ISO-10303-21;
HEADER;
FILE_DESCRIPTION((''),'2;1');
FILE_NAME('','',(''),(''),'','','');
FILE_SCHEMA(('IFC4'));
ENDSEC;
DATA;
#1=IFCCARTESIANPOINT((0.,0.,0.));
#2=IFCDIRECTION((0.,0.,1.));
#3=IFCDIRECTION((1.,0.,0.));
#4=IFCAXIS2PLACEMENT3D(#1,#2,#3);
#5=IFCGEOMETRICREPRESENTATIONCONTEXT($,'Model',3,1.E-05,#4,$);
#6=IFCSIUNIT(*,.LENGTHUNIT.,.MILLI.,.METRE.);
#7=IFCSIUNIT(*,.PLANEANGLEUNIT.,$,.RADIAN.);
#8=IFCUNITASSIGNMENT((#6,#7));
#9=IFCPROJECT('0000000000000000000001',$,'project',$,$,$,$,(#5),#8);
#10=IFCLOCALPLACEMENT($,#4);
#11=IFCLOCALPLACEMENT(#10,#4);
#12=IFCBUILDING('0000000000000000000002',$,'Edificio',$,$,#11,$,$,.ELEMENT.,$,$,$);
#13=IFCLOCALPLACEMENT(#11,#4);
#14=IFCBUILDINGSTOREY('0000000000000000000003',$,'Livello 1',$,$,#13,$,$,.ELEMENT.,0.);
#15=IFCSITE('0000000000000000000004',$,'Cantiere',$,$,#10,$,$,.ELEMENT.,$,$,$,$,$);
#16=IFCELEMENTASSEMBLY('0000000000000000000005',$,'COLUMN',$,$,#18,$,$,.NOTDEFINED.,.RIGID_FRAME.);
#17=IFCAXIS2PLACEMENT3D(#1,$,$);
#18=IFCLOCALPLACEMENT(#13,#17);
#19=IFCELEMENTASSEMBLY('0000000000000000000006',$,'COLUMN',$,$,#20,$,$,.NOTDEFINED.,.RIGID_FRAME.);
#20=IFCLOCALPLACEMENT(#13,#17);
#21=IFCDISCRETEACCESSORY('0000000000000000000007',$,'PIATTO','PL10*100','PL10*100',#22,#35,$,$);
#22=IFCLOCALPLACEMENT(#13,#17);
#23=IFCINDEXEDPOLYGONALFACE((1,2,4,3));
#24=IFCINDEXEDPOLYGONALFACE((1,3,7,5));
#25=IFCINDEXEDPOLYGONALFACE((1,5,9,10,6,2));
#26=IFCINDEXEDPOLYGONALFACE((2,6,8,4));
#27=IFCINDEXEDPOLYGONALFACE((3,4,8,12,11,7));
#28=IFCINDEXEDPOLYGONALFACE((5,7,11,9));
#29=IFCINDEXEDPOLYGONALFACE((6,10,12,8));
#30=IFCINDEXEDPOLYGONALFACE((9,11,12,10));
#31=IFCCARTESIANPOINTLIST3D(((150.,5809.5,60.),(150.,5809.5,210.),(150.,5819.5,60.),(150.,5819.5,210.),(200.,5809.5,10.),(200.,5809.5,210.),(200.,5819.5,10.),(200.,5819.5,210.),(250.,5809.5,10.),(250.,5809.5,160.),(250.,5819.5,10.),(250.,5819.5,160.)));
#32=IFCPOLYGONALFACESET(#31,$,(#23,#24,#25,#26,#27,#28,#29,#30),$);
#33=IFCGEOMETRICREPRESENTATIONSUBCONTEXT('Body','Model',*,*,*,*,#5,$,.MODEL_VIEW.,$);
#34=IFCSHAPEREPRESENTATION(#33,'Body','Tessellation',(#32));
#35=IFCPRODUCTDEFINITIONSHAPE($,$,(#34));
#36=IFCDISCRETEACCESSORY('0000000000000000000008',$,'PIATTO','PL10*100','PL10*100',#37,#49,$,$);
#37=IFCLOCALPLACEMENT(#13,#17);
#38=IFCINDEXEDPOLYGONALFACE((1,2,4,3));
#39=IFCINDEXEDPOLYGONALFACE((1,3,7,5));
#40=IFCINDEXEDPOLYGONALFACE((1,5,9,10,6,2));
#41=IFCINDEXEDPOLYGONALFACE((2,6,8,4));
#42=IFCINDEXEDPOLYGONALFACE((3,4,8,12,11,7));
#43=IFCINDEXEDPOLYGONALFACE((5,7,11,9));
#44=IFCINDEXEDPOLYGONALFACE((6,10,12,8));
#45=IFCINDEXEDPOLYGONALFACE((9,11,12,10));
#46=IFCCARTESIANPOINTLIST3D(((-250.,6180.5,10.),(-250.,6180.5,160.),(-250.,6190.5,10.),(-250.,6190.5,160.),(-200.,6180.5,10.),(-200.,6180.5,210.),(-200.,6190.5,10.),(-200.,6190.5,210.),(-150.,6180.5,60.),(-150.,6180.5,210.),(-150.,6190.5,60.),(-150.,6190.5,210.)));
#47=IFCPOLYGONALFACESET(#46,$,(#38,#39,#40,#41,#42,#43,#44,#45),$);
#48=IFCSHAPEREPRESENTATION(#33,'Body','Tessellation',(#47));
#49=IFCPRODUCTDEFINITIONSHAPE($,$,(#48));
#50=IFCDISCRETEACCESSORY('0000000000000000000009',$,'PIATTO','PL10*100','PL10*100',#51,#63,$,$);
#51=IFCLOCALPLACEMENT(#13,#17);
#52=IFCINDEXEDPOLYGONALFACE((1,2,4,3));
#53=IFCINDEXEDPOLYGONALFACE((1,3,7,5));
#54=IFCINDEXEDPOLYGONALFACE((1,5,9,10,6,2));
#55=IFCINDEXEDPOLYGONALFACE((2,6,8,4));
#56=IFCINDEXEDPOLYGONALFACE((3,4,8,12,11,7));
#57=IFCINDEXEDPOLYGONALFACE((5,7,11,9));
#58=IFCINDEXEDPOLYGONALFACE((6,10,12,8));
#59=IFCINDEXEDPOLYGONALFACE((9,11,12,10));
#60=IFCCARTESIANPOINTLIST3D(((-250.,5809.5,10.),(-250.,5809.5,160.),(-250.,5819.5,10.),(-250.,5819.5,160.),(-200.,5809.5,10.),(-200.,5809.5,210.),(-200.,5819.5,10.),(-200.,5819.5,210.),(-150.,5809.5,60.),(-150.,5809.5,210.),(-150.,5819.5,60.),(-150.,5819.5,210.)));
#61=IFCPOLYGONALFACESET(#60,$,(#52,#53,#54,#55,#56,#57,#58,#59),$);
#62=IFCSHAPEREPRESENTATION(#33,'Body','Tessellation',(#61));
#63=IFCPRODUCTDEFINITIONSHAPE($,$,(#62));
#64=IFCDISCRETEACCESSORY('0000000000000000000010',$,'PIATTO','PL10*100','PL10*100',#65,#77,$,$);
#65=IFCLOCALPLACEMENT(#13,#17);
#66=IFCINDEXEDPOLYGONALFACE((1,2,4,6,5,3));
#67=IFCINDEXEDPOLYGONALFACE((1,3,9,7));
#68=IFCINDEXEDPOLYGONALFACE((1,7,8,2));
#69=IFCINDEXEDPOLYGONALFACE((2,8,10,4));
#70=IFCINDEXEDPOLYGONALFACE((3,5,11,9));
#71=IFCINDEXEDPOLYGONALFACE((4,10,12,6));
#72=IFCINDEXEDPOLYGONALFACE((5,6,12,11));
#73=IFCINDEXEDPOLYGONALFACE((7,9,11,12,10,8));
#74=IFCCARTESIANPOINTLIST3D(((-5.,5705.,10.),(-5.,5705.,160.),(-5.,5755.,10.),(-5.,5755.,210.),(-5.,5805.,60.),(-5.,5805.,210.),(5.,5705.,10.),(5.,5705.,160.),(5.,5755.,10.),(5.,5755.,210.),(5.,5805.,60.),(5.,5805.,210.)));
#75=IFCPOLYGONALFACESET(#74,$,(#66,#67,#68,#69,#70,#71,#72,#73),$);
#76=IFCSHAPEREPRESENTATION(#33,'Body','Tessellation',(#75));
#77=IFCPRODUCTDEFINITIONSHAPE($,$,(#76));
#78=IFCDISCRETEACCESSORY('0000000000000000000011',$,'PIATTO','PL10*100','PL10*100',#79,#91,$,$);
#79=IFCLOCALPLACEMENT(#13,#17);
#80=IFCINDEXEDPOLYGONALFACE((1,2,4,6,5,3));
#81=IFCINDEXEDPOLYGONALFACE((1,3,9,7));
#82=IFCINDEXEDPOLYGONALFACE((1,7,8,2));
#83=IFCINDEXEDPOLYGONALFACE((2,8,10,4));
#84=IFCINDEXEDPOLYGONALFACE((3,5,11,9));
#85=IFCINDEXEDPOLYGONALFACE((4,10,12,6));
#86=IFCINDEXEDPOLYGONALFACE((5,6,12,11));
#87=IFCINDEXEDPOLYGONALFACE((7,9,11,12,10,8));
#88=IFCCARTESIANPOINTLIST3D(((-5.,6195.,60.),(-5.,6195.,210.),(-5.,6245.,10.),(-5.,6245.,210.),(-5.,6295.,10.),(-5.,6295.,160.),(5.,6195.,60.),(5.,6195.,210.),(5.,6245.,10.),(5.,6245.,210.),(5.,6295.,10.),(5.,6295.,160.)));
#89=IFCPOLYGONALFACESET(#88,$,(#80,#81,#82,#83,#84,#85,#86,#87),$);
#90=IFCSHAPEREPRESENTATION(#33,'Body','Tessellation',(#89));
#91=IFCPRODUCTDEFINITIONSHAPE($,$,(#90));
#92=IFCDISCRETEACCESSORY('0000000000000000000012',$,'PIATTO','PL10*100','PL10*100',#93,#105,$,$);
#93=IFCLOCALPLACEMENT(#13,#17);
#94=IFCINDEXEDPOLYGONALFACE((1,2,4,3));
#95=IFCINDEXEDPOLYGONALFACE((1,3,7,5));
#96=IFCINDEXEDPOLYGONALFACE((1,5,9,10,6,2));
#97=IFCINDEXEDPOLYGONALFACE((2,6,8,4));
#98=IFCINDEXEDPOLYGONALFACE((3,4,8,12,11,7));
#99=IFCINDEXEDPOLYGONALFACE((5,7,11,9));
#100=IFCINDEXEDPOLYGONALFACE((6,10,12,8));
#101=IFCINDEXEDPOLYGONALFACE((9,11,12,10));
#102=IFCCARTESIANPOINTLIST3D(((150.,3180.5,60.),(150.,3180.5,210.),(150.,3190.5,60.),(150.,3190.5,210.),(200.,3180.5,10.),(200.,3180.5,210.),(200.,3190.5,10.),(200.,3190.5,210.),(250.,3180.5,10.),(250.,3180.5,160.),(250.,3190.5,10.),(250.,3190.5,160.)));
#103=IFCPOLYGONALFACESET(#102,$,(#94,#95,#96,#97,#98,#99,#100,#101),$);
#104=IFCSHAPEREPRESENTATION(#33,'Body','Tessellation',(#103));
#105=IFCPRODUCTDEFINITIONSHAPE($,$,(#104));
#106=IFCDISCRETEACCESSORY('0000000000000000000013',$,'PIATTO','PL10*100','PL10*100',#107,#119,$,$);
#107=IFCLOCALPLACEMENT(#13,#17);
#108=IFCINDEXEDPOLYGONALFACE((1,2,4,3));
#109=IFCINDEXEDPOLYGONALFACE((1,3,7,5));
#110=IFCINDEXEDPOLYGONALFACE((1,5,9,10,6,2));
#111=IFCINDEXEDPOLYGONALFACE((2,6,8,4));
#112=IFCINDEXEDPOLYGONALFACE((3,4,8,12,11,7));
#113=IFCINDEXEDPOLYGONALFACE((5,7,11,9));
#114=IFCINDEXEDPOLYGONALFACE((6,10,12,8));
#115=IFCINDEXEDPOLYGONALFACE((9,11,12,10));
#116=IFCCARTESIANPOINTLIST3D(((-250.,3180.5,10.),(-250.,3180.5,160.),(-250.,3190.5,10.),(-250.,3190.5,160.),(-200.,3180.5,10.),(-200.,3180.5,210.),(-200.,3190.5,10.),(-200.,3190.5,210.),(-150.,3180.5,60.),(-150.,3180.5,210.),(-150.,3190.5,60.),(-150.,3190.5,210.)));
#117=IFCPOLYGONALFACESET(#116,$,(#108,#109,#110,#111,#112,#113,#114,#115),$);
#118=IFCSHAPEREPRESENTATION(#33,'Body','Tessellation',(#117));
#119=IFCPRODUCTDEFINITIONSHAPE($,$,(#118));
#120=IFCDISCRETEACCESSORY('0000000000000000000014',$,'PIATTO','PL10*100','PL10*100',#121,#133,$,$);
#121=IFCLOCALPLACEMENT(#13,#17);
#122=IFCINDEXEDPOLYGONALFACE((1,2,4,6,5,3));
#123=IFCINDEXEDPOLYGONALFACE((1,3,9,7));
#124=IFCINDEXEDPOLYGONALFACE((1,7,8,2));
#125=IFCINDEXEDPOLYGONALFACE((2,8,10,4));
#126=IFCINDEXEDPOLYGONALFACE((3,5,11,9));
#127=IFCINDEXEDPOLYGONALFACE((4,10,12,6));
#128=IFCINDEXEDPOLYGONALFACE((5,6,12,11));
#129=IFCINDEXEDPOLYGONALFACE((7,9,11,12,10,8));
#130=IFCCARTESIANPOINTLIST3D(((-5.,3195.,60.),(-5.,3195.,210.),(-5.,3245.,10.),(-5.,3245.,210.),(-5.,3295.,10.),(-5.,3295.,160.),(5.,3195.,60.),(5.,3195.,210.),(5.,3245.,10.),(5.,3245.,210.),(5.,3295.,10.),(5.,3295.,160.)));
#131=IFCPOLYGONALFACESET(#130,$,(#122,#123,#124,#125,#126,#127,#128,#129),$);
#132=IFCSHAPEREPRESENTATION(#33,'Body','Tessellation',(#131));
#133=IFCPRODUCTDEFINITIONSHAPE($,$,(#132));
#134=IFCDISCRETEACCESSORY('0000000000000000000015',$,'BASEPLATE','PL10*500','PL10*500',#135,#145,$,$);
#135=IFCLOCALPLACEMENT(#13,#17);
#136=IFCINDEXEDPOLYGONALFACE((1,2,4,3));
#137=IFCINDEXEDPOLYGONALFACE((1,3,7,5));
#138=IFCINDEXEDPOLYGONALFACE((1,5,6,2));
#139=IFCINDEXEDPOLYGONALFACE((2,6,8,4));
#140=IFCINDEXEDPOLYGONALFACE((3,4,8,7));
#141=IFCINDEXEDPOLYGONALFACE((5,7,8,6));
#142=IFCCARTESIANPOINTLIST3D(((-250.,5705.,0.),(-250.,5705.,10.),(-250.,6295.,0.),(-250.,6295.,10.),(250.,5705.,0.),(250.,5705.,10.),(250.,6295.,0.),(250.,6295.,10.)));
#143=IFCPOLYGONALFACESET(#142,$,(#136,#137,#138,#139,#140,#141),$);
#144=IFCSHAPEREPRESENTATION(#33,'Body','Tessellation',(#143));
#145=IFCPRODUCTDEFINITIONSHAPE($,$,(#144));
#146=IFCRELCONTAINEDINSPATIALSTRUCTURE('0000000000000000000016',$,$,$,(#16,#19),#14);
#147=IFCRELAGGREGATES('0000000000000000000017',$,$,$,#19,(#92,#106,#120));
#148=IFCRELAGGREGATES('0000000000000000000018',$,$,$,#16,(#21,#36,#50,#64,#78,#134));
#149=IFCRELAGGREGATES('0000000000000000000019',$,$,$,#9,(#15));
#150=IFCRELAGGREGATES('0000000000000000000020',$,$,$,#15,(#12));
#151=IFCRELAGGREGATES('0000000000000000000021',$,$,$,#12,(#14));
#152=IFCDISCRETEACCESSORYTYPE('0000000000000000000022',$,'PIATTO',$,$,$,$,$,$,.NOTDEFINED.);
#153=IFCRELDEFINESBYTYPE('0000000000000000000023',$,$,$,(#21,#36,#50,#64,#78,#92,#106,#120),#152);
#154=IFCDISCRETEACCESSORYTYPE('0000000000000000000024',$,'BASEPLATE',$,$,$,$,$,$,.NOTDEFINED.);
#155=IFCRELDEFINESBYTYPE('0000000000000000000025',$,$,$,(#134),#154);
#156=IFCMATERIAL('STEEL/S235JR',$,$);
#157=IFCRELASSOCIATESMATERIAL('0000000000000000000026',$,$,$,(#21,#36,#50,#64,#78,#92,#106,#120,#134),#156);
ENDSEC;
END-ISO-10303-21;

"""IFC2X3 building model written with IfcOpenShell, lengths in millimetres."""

from ifc_helpers import new_model, si_unit, frame, origin_with_axes, place, context, subcontext, project, spatial, polyline, outline, extrude, material, type_object, element, aggregate, save


model = new_model("IFC2X3")

# Units and contexts
model_context = context("Model", 3, precision=1e-05, world=origin_with_axes())
body_context = subcontext(model_context, "Body", "Model", "MODEL_VIEW")
ifc_project = project(units=[si_unit("LENGTHUNIT", "METRE", prefix="MILLI"), si_unit("PLANEANGLEUNIT", "RADIAN")], contexts=[model_context])

# Site, building, storey
site_placement = place(None, origin_with_axes())
site = spatial("IfcSite", under=ifc_project, at=site_placement, Name="Cantiere", CompositionType="ELEMENT")
building_placement = place(site_placement, origin_with_axes())
building = spatial("IfcBuilding", under=site, at=building_placement, Name="Edificio", CompositionType="ELEMENT")
storey_placement = place(building_placement, origin_with_axes())
storey = spatial("IfcBuildingStorey", under=building, at=storey_placement, Name="Livello 1", CompositionType="ELEMENT", Elevation=0.0)

# Element assemblies
assembly_1_placement = place(storey_placement, origin_with_axes())
assembly_1 = element("IfcElementAssembly", 1, at=assembly_1_placement, inside=storey, Name="COLUMN", AssemblyPlace="NOTDEFINED", PredefinedType="RIGID_FRAME")
ifc_material_1 = material(Name="STEEL/S235JR")
assembly_2_placement = place(storey_placement, origin_with_axes())
assembly_2 = element("IfcElementAssembly", 2, at=assembly_2_placement, inside=storey, Name="COLUMN", AssemblyPlace="NOTDEFINED", PredefinedType="RIGID_FRAME")

# Shared definitions
discrete_accessory_type_1 = type_object("IfcDiscreteAccessoryType", Name="PIATTO")

# Discrete accessories
discrete_accessory_1_placement = place(assembly_1_placement, frame((150.0, 5814.5, 60.0), z_axis=(0.0, -1.0, 0.0), x_axis=(0.707107, 0.0, -0.707107)))
discrete_accessory_1 = element("IfcDiscreteAccessory", 3, at=discrete_accessory_1_placement, type_object=discrete_accessory_type_1, material=ifc_material_1, Name="PIATTO", Description="PL10*100", ObjectType="PL10*100", context=body_context, shape_type="SweptSolid", body=[
    extrude(outline(polyline([(0.0, 0.0), (70.7, 0.0), (106.1, 35.4), (0.0, 141.4), (-70.7, 141.4), (-106.1, 106.1), (0.0, 0.0)])), frame((0.0, 0.0, -5.0), z_axis=(0.0, 0.0, 1.0), x_axis=(1.0, 0.0, 0.0)), (0.0, 0.0, 1.0), 10.0),
])
discrete_accessory_2_placement = place(assembly_1_placement, frame((-150.0, 6185.5, 60.0), z_axis=(0.0, 1.0, 0.0), x_axis=(-0.707107, 0.0, -0.707107)))
discrete_accessory_2 = element("IfcDiscreteAccessory", 4, at=discrete_accessory_2_placement, type_object=discrete_accessory_type_1, material=ifc_material_1, Name="PIATTO", Description="PL10*100", ObjectType="PL10*100", context=body_context, shape_type="SweptSolid", body=[
    extrude(outline(polyline([(0.0, 0.0), (70.7, 0.0), (106.1, 35.4), (0.0, 141.4), (-70.7, 141.4), (-106.1, 106.1), (0.0, 0.0)])), frame((0.0, 0.0, -5.0), z_axis=(0.0, 0.0, 1.0), x_axis=(1.0, 0.0, 0.0)), (0.0, 0.0, 1.0), 10.0),
])
discrete_accessory_3_placement = place(assembly_1_placement, frame((-150.0, 5814.5, 60.0), z_axis=(0.0, 1.0, 0.0), x_axis=(-0.707107, 0.0, -0.707107)))
discrete_accessory_3 = element("IfcDiscreteAccessory", 5, at=discrete_accessory_3_placement, type_object=discrete_accessory_type_1, material=ifc_material_1, Name="PIATTO", Description="PL10*100", ObjectType="PL10*100", context=body_context, shape_type="SweptSolid", body=[
    extrude(outline(polyline([(0.0, 0.0), (70.7, 0.0), (106.1, 35.4), (0.0, 141.4), (-70.7, 141.4), (-106.1, 106.1), (0.0, 0.0)])), frame((0.0, 0.0, -5.0), z_axis=(0.0, 0.0, 1.0), x_axis=(1.0, 0.0, 0.0)), (0.0, 0.0, 1.0), 10.0),
])
discrete_accessory_4_placement = place(assembly_1_placement, frame((0.0, 5805.0, 60.0), z_axis=(-1.0, 0.0, 0.0), x_axis=(0.0, -0.707107, -0.707107)))
discrete_accessory_4 = element("IfcDiscreteAccessory", 6, at=discrete_accessory_4_placement, type_object=discrete_accessory_type_1, material=ifc_material_1, Name="PIATTO", Description="PL10*100", ObjectType="PL10*100", context=body_context, shape_type="SweptSolid", body=[
    extrude(outline(polyline([(0.0, 0.0), (70.7, 0.0), (106.1, 35.4), (0.0, 141.4), (-70.7, 141.4), (-106.1, 106.1), (0.0, 0.0)])), frame((0.0, 0.0, -5.0), z_axis=(0.0, 0.0, 1.0), x_axis=(1.0, 0.0, 0.0)), (0.0, 0.0, 1.0), 10.0),
])
discrete_accessory_5_placement = place(assembly_1_placement, frame((0.0, 6195.0, 60.0), z_axis=(1.0, 0.0, 0.0), x_axis=(0.0, 0.707107, -0.707107)))
discrete_accessory_5 = element("IfcDiscreteAccessory", 7, at=discrete_accessory_5_placement, type_object=discrete_accessory_type_1, material=ifc_material_1, Name="PIATTO", Description="PL10*100", ObjectType="PL10*100", context=body_context, shape_type="SweptSolid", body=[
    extrude(outline(polyline([(0.0, 0.0), (70.7, 0.0), (106.1, 35.4), (0.0, 141.4), (-70.7, 141.4), (-106.1, 106.1), (0.0, 0.0)])), frame((0.0, 0.0, -5.0), z_axis=(0.0, 0.0, 1.0), x_axis=(1.0, 0.0, 0.0)), (0.0, 0.0, 1.0), 10.0),
])
discrete_accessory_6_placement = place(assembly_2_placement, frame((150.0, 3185.5, 60.0), z_axis=(0.0, -1.0, 0.0), x_axis=(0.707107, 0.0, -0.707107)))
discrete_accessory_6 = element("IfcDiscreteAccessory", 8, at=discrete_accessory_6_placement, type_object=discrete_accessory_type_1, material=ifc_material_1, Name="PIATTO", Description="PL10*100", ObjectType="PL10*100", context=body_context, shape_type="SweptSolid", body=[
    extrude(outline(polyline([(0.0, 0.0), (70.7, 0.0), (106.1, 35.4), (0.0, 141.4), (-70.7, 141.4), (-106.1, 106.1), (0.0, 0.0)])), frame((0.0, 0.0, -5.0), z_axis=(0.0, 0.0, 1.0), x_axis=(1.0, 0.0, 0.0)), (0.0, 0.0, 1.0), 10.0),
])
discrete_accessory_7_placement = place(assembly_2_placement, frame((-150.0, 3185.5, 60.0), z_axis=(0.0, 1.0, 0.0), x_axis=(-0.707107, 0.0, -0.707107)))
discrete_accessory_7 = element("IfcDiscreteAccessory", 9, at=discrete_accessory_7_placement, type_object=discrete_accessory_type_1, material=ifc_material_1, Name="PIATTO", Description="PL10*100", ObjectType="PL10*100", context=body_context, shape_type="SweptSolid", body=[
    extrude(outline(polyline([(0.0, 0.0), (70.7, 0.0), (106.1, 35.4), (0.0, 141.4), (-70.7, 141.4), (-106.1, 106.1), (0.0, 0.0)])), frame((0.0, 0.0, -5.0), z_axis=(0.0, 0.0, 1.0), x_axis=(1.0, 0.0, 0.0)), (0.0, 0.0, 1.0), 10.0),
])
discrete_accessory_8_placement = place(assembly_2_placement, frame((0.0, 3195.0, 60.0), z_axis=(1.0, 0.0, 0.0), x_axis=(0.0, 0.707107, -0.707107)))
discrete_accessory_8 = element("IfcDiscreteAccessory", 10, at=discrete_accessory_8_placement, type_object=discrete_accessory_type_1, material=ifc_material_1, Name="PIATTO", Description="PL10*100", ObjectType="PL10*100", context=body_context, shape_type="SweptSolid", body=[
    extrude(outline(polyline([(0.0, 0.0), (70.7, 0.0), (106.1, 35.4), (0.0, 141.4), (-70.7, 141.4), (-106.1, 106.1), (0.0, 0.0)])), frame((0.0, 0.0, -5.0), z_axis=(0.0, 0.0, 1.0), x_axis=(1.0, 0.0, 0.0)), (0.0, 0.0, 1.0), 10.0),
])

aggregate(assembly_2, [discrete_accessory_6, discrete_accessory_7, discrete_accessory_8])

# Discrete accessory
discrete_accessory_type_2 = type_object("IfcDiscreteAccessoryType", Name="BASEPLATE")
discrete_accessory_9_placement = place(assembly_1_placement, frame((0.0, 5705.0, 5.0), z_axis=(0.0, 0.0, 1.0), x_axis=(0.0, 1.0, 0.0)))
discrete_accessory_9 = element("IfcDiscreteAccessory", 11, at=discrete_accessory_9_placement, type_object=discrete_accessory_type_2, material=ifc_material_1, Name="BASEPLATE", Description="PL10*500", ObjectType="PL10*500", context=body_context, shape_type="SweptSolid", body=[
    extrude(outline(polyline([(0.0, 250.0), (590.0, 250.0), (590.0, -250.0), (0.0, -250.0), (0.0, 250.0)])), frame((0.0, 0.0, -5.0), z_axis=(0.0, 0.0, 1.0), x_axis=(1.0, 0.0, 0.0)), (0.0, 0.0, 1.0), 10.0),
])
aggregate(assembly_1, [discrete_accessory_1, discrete_accessory_2, discrete_accessory_3, discrete_accessory_4, discrete_accessory_5, discrete_accessory_9])

save(model, "model.ifc")
